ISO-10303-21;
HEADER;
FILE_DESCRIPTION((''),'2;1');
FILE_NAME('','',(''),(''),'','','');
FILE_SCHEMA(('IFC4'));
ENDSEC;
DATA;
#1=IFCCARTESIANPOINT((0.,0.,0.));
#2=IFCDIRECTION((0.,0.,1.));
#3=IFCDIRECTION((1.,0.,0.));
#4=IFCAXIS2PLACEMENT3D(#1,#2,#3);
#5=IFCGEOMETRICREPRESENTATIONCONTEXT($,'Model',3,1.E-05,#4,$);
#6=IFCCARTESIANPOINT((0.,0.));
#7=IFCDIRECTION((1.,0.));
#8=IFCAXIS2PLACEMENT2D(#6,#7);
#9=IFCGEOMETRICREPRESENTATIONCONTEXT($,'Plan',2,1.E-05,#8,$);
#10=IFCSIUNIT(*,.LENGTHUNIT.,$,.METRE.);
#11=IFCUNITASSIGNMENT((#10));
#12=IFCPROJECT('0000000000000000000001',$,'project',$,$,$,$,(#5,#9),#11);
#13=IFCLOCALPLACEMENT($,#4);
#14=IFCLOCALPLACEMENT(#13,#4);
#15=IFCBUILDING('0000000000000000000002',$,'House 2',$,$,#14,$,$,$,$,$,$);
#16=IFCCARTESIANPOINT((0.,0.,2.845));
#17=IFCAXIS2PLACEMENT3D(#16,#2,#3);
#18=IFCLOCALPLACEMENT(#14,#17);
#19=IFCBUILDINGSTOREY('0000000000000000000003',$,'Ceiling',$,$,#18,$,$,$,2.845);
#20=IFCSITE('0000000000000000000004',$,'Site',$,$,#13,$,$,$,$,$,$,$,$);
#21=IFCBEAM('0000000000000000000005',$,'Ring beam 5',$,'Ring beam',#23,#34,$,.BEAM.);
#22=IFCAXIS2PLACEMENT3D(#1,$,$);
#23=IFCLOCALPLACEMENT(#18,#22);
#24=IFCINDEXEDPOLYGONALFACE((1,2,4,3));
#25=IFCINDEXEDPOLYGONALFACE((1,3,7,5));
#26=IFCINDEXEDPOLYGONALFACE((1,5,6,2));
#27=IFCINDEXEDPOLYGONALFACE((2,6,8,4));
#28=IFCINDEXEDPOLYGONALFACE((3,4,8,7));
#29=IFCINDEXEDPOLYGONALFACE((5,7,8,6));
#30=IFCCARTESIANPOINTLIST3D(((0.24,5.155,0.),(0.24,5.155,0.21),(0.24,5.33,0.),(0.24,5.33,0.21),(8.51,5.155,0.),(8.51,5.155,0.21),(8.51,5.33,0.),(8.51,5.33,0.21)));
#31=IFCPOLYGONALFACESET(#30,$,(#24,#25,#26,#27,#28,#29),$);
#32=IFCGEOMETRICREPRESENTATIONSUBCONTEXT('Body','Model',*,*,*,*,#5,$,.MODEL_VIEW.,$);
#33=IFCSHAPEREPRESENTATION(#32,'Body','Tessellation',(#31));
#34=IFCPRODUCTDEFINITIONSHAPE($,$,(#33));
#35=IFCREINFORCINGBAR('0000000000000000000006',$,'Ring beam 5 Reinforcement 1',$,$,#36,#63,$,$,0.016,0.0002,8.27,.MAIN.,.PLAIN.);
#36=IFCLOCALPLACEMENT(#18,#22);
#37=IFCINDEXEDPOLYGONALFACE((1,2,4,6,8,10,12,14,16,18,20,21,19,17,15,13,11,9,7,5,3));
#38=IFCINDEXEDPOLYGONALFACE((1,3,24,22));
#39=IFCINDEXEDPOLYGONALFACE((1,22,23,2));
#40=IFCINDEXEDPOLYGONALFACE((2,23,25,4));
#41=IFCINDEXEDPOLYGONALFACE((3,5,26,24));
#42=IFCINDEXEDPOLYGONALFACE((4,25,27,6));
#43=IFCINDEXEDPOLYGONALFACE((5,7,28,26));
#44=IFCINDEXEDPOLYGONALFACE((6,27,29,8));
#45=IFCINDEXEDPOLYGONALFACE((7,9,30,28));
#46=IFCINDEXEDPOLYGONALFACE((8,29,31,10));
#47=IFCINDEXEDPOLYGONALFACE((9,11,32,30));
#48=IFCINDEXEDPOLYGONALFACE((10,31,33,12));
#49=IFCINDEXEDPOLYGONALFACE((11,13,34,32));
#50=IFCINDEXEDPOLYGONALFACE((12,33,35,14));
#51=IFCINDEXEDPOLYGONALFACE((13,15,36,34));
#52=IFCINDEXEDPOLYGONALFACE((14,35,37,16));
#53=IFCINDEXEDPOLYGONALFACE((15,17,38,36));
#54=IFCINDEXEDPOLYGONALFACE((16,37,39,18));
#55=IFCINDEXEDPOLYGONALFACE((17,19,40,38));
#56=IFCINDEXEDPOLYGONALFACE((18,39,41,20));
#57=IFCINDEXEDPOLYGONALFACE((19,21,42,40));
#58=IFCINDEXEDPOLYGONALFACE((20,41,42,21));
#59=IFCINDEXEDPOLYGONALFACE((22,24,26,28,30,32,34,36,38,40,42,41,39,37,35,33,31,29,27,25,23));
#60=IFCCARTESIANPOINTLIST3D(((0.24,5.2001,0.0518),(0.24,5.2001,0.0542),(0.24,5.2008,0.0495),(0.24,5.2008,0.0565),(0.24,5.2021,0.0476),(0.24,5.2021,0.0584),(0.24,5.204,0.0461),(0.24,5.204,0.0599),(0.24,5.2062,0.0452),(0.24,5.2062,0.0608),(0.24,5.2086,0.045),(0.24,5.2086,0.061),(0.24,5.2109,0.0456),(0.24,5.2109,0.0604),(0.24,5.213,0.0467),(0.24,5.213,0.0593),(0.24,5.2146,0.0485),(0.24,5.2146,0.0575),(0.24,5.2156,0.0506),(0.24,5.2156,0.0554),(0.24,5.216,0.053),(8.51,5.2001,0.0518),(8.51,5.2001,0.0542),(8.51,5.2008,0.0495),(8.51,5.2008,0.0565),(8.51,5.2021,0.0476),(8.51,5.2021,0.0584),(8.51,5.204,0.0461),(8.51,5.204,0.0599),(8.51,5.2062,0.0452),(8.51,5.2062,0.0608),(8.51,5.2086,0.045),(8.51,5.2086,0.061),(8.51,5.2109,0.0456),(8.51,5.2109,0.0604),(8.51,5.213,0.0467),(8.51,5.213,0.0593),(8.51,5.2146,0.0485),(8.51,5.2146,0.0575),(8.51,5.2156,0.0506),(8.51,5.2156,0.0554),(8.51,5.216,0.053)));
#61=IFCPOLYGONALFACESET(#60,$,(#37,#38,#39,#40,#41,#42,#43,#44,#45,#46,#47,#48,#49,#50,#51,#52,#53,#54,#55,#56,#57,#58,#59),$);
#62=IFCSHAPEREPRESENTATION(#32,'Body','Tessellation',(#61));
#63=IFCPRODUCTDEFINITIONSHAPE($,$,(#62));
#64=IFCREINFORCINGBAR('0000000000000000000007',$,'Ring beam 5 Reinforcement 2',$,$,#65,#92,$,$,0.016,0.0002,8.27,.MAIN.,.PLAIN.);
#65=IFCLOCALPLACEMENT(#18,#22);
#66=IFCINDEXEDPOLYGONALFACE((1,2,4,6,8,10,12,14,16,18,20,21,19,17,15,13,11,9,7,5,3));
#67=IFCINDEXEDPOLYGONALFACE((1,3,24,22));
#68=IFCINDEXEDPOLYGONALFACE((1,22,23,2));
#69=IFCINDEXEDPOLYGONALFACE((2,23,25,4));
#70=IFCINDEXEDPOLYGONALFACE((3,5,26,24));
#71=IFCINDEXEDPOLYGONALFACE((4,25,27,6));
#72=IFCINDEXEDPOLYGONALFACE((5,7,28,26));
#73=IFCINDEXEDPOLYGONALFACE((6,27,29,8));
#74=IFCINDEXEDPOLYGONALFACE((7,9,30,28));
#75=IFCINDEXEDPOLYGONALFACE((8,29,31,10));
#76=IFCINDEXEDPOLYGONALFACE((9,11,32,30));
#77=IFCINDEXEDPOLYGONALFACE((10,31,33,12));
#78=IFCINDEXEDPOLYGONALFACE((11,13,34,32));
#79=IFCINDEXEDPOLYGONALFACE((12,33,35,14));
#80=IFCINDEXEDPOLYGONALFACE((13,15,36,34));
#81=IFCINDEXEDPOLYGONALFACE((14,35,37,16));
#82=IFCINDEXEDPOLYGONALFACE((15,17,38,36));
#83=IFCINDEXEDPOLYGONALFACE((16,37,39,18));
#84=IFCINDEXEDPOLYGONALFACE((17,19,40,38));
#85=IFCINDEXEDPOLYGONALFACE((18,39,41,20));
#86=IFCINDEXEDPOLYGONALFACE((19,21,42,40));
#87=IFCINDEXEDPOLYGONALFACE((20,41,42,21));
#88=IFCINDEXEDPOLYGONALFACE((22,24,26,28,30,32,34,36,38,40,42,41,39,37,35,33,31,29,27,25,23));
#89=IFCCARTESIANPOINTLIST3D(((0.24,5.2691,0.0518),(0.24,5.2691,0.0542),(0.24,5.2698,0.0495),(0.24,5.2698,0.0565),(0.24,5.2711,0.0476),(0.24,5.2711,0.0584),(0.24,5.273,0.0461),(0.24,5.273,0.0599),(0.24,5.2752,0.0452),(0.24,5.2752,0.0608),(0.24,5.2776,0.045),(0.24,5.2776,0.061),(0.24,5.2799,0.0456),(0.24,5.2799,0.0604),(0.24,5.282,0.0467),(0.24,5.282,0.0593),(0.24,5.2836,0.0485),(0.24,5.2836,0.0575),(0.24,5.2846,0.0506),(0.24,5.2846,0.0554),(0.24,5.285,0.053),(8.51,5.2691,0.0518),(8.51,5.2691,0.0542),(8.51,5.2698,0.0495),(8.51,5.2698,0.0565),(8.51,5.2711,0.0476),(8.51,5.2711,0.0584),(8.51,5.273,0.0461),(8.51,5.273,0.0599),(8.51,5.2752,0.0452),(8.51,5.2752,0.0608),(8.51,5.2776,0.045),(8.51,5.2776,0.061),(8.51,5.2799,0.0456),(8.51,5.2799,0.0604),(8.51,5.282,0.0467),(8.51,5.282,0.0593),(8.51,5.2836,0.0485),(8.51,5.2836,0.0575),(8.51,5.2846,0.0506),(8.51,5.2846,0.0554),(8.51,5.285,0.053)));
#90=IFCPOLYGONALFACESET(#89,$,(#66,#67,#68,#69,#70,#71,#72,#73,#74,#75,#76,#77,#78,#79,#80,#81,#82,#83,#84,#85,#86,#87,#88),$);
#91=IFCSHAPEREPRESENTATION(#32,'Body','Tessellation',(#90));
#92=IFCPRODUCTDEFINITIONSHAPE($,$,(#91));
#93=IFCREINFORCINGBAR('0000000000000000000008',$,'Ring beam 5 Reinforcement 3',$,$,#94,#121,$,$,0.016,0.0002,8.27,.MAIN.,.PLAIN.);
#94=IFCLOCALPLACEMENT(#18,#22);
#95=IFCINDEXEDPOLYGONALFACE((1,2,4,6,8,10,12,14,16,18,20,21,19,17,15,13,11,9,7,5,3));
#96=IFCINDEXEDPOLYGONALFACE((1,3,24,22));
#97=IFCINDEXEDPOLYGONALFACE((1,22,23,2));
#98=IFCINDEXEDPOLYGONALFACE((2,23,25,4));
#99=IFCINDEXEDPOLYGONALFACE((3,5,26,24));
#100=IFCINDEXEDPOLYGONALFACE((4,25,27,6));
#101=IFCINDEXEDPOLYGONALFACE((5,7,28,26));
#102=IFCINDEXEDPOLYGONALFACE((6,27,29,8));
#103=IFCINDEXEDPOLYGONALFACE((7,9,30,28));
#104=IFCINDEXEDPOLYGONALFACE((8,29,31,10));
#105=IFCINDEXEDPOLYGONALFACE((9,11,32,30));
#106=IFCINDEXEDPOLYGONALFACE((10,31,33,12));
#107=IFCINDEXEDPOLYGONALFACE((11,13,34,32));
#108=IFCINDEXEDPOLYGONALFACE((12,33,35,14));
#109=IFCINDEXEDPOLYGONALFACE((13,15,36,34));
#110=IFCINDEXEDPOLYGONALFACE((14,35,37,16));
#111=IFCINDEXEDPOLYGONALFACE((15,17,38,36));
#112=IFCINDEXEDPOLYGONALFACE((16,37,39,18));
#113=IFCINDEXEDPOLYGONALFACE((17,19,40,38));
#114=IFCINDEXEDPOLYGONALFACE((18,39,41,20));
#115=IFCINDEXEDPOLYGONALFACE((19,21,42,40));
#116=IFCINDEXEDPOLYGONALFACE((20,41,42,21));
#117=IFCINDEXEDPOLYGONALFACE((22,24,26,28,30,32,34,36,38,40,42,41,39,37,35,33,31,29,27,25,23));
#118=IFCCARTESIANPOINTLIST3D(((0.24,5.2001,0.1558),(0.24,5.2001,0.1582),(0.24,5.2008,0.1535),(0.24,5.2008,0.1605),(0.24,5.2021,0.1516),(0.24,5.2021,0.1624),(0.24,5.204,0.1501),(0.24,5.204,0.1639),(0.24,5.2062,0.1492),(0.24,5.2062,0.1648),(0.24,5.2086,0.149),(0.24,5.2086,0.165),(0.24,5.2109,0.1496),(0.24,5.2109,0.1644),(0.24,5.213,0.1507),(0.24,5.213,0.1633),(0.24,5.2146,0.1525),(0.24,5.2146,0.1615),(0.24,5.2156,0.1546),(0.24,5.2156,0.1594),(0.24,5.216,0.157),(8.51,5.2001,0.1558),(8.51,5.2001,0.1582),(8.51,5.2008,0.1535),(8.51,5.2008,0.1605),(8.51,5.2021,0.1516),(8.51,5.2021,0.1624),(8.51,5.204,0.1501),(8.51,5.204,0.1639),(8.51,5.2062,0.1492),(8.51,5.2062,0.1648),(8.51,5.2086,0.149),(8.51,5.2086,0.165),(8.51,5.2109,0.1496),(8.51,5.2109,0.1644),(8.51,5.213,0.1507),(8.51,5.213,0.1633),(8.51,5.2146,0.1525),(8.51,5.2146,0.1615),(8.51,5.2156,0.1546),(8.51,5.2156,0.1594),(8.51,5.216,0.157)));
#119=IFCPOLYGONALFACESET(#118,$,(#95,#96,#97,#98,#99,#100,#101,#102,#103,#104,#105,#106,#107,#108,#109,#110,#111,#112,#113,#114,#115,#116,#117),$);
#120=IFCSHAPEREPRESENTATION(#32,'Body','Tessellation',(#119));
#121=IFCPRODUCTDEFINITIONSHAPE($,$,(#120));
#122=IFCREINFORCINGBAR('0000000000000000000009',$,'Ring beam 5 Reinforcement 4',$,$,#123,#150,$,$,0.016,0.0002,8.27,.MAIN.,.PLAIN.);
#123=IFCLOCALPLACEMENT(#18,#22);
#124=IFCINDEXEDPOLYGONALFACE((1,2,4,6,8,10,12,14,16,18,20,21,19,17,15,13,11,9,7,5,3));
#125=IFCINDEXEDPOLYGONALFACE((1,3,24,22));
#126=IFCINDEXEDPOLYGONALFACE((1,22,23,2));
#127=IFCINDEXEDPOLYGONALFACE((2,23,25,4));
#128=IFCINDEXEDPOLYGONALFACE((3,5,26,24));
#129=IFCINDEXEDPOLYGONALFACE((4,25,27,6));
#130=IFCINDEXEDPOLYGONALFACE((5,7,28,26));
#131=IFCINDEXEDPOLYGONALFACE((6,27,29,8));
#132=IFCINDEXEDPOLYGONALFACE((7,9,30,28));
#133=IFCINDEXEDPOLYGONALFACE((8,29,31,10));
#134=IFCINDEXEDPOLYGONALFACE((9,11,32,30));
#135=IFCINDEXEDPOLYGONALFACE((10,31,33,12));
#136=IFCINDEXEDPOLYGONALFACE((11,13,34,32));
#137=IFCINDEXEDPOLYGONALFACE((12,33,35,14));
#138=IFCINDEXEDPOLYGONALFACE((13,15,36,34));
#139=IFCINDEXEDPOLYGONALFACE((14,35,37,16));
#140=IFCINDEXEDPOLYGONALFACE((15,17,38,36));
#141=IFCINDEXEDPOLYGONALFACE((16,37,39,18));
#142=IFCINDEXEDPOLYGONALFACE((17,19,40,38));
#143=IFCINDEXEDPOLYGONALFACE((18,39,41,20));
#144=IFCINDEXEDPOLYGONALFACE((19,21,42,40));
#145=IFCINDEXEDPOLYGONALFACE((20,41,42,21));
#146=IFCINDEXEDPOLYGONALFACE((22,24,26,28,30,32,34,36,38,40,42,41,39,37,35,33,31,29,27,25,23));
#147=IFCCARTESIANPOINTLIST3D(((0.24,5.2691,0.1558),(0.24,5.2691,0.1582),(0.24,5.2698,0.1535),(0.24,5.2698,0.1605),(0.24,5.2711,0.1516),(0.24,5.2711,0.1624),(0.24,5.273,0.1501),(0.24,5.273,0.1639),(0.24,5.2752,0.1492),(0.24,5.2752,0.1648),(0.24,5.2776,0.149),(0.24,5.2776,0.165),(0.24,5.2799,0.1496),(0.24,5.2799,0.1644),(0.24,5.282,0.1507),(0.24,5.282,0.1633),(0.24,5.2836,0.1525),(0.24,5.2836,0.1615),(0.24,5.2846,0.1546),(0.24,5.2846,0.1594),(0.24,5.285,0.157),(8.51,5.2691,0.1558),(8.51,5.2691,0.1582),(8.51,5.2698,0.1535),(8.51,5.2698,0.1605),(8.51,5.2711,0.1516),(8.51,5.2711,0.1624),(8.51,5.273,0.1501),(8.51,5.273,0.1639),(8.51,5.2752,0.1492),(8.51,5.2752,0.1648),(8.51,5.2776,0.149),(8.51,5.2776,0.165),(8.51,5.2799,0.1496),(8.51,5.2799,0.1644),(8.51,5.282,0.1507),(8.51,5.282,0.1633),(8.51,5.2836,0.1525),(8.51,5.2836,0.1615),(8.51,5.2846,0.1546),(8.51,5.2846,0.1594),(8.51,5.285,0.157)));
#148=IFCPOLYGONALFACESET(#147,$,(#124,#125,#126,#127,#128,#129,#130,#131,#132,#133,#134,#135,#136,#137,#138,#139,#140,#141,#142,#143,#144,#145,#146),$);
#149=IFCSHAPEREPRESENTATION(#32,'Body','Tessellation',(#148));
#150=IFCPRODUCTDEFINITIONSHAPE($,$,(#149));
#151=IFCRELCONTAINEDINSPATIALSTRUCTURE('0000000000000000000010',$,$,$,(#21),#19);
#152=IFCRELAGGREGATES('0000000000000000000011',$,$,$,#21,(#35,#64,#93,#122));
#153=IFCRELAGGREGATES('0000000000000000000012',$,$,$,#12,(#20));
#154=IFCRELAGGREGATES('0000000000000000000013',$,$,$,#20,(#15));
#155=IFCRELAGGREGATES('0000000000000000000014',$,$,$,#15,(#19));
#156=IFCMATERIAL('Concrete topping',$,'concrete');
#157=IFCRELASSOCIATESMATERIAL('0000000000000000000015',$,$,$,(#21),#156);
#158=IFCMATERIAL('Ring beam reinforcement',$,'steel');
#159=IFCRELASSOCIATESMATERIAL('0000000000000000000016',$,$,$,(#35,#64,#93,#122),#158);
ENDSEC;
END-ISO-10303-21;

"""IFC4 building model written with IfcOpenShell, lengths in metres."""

from ifc_helpers import new_model, si_unit, frame, origin_with_axes, origin_2d, origin_2d_with_axis, place, context, subcontext, project, spatial, circle_curve, rectangle, outline, extrude, material, element, aggregate, save


model = new_model("IFC4")

# Units and contexts
model_context = context("Model", 3, precision=1e-05, world=origin_with_axes())
plan_context = context("Plan", 2, precision=1e-05, world=origin_2d_with_axis())
body_context_1 = subcontext(model_context, "Body", "Model", "MODEL_VIEW")
ifc_project = project(units=[si_unit("LENGTHUNIT", "METRE")], contexts=[model_context, plan_context])

# Site, building, storey
site_placement = place(None, origin_with_axes())
building_placement = place(site_placement, origin_with_axes())
storey_placement = place(building_placement, frame((0.0, 0.0, 2.845), z_axis=(0.0, 0.0, 1.0), x_axis=(1.0, 0.0, 0.0)))
site = spatial("IfcSite", under=ifc_project, at=site_placement, Name="Site")
building = spatial("IfcBuilding", under=site, at=building_placement, Name="House 2")
storey = spatial("IfcBuildingStorey", under=building, at=storey_placement, Name="Ceiling", Elevation=2.845)

# Beam
ifc_material_1 = material(Name="Concrete topping", Category="concrete")
beam_1_placement = place(storey_placement, frame((0.24, 5.2425, 0.105), z_axis=(0.0, 0.0, 1.0), x_axis=(1.0, 0.0, 0.0)))
beam_1 = element("IfcBeam", 1, at=beam_1_placement, inside=storey, material=ifc_material_1, Name="Ring beam 5", ObjectType="Ring beam", PredefinedType="BEAM", context=body_context_1, shape_type="SweptSolid", body=[
    extrude(rectangle(XDim=0.175, YDim=0.21), frame((0.0, 0.0, 0.0), z_axis=(1.0, 0.0, 0.0), x_axis=(0.0, 1.0, 0.0)), (0.0, 0.0, 1.0), 8.27),
])

# Reinforcing bars
ifc_material_2 = material(Name="Ring beam reinforcement", Category="steel")
reinforcing_bar_1_placement = place(beam_1_placement, frame((0.0, -0.0345, -0.052), z_axis=(0.0, 0.0, 1.0), x_axis=(1.0, 0.0, 0.0)))
reinforcing_bar_1 = element("IfcReinforcingBar", 2, at=reinforcing_bar_1_placement, material=ifc_material_2, Name="Ring beam 5 Reinforcement 1", BarLength=8.27, BarSurface="PLAIN", CrossSectionArea=0.0002, NominalDiameter=0.016, PredefinedType="MAIN", context=body_context_1, shape_type="SweptSolid", body=[
    extrude(outline(circle_curve(origin_2d(), 0.008)), frame((0.0, 0.0, 0.0), z_axis=(1.0, 0.0, 0.0), x_axis=(0.0, 1.0, 0.0)), (0.0, 0.0, 1.0), 8.27),
])
reinforcing_bar_2_placement = place(beam_1_placement, frame((0.0, 0.0345, -0.052), z_axis=(0.0, 0.0, 1.0), x_axis=(1.0, 0.0, 0.0)))
reinforcing_bar_2 = element("IfcReinforcingBar", 3, at=reinforcing_bar_2_placement, material=ifc_material_2, Name="Ring beam 5 Reinforcement 2", BarLength=8.27, BarSurface="PLAIN", CrossSectionArea=0.0002, NominalDiameter=0.016, PredefinedType="MAIN", context=body_context_1, shape_type="SweptSolid", body=[
    extrude(outline(circle_curve(origin_2d(), 0.008)), frame((0.0, 0.0, 0.0), z_axis=(1.0, 0.0, 0.0), x_axis=(0.0, 1.0, 0.0)), (0.0, 0.0, 1.0), 8.27),
])
reinforcing_bar_3_placement = place(beam_1_placement, frame((0.0, -0.0345, 0.052), z_axis=(0.0, 0.0, 1.0), x_axis=(1.0, 0.0, 0.0)))
reinforcing_bar_3 = element("IfcReinforcingBar", 4, at=reinforcing_bar_3_placement, material=ifc_material_2, Name="Ring beam 5 Reinforcement 3", BarLength=8.27, BarSurface="PLAIN", CrossSectionArea=0.0002, NominalDiameter=0.016, PredefinedType="MAIN", context=body_context_1, shape_type="SweptSolid", body=[
    extrude(outline(circle_curve(origin_2d(), 0.008)), frame((0.0, 0.0, 0.0), z_axis=(1.0, 0.0, 0.0), x_axis=(0.0, 1.0, 0.0)), (0.0, 0.0, 1.0), 8.27),
])
reinforcing_bar_4_placement = place(beam_1_placement, frame((0.0, 0.0345, 0.052), z_axis=(0.0, 0.0, 1.0), x_axis=(1.0, 0.0, 0.0)))
reinforcing_bar_4 = element("IfcReinforcingBar", 5, at=reinforcing_bar_4_placement, material=ifc_material_2, Name="Ring beam 5 Reinforcement 4", BarLength=8.27, BarSurface="PLAIN", CrossSectionArea=0.0002, NominalDiameter=0.016, PredefinedType="MAIN", context=body_context_1, shape_type="SweptSolid", body=[
    extrude(outline(circle_curve(origin_2d(), 0.008)), frame((0.0, 0.0, 0.0), z_axis=(1.0, 0.0, 0.0), x_axis=(0.0, 1.0, 0.0)), (0.0, 0.0, 1.0), 8.27),
])
aggregate(beam_1, [reinforcing_bar_1, reinforcing_bar_2, reinforcing_bar_3, reinforcing_bar_4])

save(model, "model.ifc")
